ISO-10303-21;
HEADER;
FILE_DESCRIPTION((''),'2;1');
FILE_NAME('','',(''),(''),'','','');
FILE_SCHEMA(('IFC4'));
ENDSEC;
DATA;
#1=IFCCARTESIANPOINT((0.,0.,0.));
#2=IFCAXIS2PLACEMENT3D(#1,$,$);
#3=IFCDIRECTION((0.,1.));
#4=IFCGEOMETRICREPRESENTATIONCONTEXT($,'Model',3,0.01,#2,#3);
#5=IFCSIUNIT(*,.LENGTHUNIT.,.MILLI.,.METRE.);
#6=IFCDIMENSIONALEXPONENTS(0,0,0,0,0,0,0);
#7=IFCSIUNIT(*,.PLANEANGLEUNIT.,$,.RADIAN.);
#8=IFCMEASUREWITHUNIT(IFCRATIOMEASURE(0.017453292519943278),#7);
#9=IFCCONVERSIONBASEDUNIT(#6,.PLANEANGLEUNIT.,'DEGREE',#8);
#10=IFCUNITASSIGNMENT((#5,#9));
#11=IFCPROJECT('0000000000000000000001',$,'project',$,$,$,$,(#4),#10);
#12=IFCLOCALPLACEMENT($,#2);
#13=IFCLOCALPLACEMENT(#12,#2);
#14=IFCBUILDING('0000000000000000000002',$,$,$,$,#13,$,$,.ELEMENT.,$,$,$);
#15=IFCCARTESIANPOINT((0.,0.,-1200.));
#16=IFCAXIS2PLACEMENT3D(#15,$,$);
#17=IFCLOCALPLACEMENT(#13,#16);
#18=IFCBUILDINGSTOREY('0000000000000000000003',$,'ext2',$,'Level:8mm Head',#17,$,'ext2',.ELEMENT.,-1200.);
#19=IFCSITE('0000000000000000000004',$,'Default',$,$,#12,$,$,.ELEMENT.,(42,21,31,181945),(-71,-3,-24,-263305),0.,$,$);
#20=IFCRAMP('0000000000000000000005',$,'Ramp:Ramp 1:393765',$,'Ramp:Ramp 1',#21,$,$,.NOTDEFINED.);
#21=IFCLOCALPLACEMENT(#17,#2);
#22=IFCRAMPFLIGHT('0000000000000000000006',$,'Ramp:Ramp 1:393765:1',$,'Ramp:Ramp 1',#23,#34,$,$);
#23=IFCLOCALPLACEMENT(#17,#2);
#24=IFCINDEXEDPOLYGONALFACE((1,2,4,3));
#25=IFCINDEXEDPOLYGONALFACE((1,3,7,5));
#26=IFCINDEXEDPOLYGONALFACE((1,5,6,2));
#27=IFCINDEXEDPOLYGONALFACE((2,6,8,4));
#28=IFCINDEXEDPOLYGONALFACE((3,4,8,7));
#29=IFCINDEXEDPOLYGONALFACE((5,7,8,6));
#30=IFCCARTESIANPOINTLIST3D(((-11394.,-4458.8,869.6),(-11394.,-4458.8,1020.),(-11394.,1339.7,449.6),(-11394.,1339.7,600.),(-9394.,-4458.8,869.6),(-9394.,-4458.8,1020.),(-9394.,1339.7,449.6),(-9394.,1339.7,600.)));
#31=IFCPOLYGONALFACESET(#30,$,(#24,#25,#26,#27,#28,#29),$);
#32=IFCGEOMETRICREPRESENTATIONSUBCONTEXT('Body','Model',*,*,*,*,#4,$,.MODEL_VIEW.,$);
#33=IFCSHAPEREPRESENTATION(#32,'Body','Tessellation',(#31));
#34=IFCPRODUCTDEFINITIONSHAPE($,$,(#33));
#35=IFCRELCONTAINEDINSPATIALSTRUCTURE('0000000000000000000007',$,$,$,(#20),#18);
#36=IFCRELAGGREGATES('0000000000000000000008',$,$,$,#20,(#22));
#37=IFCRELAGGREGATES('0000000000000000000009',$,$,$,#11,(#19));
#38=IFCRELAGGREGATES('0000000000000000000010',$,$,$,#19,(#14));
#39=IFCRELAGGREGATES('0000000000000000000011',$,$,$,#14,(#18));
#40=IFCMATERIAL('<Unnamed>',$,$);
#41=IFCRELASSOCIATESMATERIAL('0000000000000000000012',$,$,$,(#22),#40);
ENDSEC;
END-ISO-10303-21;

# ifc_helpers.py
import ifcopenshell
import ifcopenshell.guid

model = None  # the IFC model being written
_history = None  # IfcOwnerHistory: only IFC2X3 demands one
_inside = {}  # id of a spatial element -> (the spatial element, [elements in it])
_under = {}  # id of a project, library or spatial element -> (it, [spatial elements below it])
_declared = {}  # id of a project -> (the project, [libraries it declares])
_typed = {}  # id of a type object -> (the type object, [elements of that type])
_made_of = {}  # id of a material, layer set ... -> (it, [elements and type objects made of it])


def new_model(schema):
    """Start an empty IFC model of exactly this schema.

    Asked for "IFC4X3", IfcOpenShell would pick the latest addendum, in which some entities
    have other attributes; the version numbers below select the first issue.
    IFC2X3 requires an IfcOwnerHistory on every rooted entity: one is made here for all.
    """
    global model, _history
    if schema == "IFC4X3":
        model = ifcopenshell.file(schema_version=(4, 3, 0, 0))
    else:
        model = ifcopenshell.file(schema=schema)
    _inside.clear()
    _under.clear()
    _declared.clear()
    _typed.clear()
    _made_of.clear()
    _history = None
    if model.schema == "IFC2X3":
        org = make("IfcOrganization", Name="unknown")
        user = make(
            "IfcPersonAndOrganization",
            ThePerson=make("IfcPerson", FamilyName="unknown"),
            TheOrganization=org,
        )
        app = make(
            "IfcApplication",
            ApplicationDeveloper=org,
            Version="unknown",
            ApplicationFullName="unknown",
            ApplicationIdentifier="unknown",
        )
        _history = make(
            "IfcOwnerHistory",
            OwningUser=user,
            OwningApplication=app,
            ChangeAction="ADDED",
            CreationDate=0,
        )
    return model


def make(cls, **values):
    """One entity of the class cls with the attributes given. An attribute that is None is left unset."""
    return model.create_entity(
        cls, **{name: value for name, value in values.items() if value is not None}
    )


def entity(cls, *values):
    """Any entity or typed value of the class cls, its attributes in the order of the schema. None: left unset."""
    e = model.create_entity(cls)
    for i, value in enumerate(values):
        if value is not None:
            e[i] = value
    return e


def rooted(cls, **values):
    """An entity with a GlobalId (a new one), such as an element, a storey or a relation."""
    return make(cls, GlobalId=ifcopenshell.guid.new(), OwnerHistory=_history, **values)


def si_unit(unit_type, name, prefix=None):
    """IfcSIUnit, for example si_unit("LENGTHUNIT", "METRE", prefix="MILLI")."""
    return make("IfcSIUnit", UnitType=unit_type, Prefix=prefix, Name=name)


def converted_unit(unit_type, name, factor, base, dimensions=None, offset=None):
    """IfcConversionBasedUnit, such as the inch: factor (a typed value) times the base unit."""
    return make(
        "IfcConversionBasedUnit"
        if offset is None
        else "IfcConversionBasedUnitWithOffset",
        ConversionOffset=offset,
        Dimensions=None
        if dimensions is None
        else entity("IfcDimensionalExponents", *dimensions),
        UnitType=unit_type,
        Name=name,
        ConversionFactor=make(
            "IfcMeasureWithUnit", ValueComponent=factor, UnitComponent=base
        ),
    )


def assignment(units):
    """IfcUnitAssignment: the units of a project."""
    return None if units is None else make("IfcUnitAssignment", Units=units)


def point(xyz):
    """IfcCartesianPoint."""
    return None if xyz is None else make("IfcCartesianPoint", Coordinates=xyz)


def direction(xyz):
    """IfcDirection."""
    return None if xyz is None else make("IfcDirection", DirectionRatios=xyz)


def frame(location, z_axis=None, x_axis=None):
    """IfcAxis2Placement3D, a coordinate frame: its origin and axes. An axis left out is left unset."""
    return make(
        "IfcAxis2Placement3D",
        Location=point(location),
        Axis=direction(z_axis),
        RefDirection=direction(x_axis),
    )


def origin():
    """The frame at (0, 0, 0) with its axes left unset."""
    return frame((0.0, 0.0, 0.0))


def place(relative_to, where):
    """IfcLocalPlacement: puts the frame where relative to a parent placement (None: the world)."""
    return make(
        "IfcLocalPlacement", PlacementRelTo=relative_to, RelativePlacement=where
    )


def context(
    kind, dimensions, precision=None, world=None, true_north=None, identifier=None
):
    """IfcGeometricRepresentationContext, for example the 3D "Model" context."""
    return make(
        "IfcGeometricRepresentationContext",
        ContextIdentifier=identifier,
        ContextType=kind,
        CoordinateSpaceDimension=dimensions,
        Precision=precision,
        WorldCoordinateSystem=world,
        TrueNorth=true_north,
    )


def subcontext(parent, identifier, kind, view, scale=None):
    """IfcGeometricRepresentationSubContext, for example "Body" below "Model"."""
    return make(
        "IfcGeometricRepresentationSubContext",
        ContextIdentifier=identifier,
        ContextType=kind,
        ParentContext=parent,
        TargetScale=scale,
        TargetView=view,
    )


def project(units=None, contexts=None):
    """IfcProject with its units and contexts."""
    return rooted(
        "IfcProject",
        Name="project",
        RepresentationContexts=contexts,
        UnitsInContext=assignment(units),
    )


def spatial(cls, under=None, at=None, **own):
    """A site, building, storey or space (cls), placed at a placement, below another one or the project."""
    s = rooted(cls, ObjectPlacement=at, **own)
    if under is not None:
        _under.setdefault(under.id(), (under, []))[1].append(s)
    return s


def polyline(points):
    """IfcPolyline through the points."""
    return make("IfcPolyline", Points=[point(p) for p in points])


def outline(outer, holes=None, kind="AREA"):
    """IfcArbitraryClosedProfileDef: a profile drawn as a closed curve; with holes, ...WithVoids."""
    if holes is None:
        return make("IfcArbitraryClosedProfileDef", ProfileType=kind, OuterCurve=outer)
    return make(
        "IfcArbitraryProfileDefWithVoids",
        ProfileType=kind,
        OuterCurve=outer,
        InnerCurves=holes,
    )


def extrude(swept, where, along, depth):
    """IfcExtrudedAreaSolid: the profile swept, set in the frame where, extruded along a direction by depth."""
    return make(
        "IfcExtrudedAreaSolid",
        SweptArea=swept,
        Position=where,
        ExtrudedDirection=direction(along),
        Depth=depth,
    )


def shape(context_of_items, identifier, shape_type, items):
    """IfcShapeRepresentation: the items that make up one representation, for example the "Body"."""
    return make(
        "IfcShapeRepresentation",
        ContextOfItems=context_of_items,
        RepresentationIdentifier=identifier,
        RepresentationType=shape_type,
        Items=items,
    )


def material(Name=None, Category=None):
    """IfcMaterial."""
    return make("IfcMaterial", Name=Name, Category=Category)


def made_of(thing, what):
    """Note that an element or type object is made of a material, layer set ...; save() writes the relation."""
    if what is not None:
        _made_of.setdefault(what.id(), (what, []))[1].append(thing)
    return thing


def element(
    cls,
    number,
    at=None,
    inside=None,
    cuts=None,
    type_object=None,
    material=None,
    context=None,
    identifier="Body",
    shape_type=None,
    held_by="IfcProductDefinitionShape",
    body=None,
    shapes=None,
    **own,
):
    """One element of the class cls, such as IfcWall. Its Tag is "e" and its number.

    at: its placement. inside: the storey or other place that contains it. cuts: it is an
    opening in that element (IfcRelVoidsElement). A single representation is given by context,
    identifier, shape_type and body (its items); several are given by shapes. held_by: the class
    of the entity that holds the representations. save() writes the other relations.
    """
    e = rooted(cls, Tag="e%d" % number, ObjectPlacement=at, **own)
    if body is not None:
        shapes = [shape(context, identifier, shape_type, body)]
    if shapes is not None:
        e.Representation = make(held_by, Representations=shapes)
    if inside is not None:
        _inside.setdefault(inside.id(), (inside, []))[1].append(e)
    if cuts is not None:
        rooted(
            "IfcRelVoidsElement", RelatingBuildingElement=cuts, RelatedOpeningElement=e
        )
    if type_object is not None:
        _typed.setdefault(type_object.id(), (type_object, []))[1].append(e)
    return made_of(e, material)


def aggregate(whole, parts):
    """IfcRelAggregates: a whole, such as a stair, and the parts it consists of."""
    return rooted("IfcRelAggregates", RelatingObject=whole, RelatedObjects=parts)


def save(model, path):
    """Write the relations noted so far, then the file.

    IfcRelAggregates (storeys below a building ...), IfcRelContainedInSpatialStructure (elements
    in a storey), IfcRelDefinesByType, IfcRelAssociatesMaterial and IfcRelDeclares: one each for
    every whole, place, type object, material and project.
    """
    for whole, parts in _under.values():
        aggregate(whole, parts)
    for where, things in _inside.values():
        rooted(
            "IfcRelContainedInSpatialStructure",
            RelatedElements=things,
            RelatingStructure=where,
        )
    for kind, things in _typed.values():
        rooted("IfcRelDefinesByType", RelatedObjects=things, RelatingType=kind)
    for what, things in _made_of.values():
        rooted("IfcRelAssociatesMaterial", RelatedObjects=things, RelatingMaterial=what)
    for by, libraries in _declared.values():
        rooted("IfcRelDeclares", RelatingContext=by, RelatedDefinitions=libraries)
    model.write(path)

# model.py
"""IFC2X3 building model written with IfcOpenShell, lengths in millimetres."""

from ifc_helpers import new_model, entity, si_unit, converted_unit, direction, frame, origin, place, context, subcontext, project, spatial, polyline, outline, extrude, material, element, aggregate, save


model = new_model("IFC2X3")

# Units and contexts
model_context = context("Model", 3, precision=0.01, world=origin(), true_north=direction((0.0, 1.0)))
body_context = subcontext(model_context, "Body", "Model", "MODEL_VIEW")
ifc_project = project(units=[si_unit("LENGTHUNIT", "METRE", prefix="MILLI"), converted_unit("PLANEANGLEUNIT", "DEGREE", entity("IfcRatioMeasure", 0.017453292519943278), si_unit("PLANEANGLEUNIT", "RADIAN"), dimensions=[0, 0, 0, 0, 0, 0, 0])], contexts=[model_context])

# Site, building, storey
site_placement = place(None, origin())
site = spatial("IfcSite", under=ifc_project, at=site_placement, Name="Default", CompositionType="ELEMENT", RefLatitude=(42, 21, 31, 181945), RefLongitude=(-71, -3, -24, -263305), RefElevation=0.0)
building_placement = place(site_placement, origin())
building = spatial("IfcBuilding", under=site, at=building_placement, CompositionType="ELEMENT")
storey_placement = place(building_placement, frame((0.0, 0.0, -1200.0)))
storey = spatial("IfcBuildingStorey", under=building, at=storey_placement, Name="ext2", ObjectType="Level:8mm Head", LongName="ext2", CompositionType="ELEMENT", Elevation=-1200.0)

# Ramp, ramp flight
ramp_placement = place(storey_placement, origin())
ramp = element("IfcRamp", 1, at=ramp_placement, inside=storey, Name="Ramp:Ramp 1:393765", ObjectType="Ramp:Ramp 1", ShapeType="NOTDEFINED")
ifc_material = material(Name="<Unnamed>")
ramp_flight_placement = place(ramp_placement, origin())
ramp_flight = element("IfcRampFlight", 2, at=ramp_flight_placement, material=ifc_material, Name="Ramp:Ramp 1:393765:1", ObjectType="Ramp:Ramp 1", context=body_context, shape_type="SweptSolid", body=[
    extrude(outline(polyline([(-285.2, -2899.2), (-134.8, -2899.2), (285.2, 2899.2), (134.8, 2899.2), (-285.2, -2899.2)])), frame((-11394.0, -1559.5, 734.8), z_axis=(1.0, 0.0, 0.0), x_axis=(0.0, 0.0, -1.0)), (0.0, 0.0, 1.0), 2000.0),
])
aggregate(ramp, [ramp_flight])

save(model, "model.ifc")
